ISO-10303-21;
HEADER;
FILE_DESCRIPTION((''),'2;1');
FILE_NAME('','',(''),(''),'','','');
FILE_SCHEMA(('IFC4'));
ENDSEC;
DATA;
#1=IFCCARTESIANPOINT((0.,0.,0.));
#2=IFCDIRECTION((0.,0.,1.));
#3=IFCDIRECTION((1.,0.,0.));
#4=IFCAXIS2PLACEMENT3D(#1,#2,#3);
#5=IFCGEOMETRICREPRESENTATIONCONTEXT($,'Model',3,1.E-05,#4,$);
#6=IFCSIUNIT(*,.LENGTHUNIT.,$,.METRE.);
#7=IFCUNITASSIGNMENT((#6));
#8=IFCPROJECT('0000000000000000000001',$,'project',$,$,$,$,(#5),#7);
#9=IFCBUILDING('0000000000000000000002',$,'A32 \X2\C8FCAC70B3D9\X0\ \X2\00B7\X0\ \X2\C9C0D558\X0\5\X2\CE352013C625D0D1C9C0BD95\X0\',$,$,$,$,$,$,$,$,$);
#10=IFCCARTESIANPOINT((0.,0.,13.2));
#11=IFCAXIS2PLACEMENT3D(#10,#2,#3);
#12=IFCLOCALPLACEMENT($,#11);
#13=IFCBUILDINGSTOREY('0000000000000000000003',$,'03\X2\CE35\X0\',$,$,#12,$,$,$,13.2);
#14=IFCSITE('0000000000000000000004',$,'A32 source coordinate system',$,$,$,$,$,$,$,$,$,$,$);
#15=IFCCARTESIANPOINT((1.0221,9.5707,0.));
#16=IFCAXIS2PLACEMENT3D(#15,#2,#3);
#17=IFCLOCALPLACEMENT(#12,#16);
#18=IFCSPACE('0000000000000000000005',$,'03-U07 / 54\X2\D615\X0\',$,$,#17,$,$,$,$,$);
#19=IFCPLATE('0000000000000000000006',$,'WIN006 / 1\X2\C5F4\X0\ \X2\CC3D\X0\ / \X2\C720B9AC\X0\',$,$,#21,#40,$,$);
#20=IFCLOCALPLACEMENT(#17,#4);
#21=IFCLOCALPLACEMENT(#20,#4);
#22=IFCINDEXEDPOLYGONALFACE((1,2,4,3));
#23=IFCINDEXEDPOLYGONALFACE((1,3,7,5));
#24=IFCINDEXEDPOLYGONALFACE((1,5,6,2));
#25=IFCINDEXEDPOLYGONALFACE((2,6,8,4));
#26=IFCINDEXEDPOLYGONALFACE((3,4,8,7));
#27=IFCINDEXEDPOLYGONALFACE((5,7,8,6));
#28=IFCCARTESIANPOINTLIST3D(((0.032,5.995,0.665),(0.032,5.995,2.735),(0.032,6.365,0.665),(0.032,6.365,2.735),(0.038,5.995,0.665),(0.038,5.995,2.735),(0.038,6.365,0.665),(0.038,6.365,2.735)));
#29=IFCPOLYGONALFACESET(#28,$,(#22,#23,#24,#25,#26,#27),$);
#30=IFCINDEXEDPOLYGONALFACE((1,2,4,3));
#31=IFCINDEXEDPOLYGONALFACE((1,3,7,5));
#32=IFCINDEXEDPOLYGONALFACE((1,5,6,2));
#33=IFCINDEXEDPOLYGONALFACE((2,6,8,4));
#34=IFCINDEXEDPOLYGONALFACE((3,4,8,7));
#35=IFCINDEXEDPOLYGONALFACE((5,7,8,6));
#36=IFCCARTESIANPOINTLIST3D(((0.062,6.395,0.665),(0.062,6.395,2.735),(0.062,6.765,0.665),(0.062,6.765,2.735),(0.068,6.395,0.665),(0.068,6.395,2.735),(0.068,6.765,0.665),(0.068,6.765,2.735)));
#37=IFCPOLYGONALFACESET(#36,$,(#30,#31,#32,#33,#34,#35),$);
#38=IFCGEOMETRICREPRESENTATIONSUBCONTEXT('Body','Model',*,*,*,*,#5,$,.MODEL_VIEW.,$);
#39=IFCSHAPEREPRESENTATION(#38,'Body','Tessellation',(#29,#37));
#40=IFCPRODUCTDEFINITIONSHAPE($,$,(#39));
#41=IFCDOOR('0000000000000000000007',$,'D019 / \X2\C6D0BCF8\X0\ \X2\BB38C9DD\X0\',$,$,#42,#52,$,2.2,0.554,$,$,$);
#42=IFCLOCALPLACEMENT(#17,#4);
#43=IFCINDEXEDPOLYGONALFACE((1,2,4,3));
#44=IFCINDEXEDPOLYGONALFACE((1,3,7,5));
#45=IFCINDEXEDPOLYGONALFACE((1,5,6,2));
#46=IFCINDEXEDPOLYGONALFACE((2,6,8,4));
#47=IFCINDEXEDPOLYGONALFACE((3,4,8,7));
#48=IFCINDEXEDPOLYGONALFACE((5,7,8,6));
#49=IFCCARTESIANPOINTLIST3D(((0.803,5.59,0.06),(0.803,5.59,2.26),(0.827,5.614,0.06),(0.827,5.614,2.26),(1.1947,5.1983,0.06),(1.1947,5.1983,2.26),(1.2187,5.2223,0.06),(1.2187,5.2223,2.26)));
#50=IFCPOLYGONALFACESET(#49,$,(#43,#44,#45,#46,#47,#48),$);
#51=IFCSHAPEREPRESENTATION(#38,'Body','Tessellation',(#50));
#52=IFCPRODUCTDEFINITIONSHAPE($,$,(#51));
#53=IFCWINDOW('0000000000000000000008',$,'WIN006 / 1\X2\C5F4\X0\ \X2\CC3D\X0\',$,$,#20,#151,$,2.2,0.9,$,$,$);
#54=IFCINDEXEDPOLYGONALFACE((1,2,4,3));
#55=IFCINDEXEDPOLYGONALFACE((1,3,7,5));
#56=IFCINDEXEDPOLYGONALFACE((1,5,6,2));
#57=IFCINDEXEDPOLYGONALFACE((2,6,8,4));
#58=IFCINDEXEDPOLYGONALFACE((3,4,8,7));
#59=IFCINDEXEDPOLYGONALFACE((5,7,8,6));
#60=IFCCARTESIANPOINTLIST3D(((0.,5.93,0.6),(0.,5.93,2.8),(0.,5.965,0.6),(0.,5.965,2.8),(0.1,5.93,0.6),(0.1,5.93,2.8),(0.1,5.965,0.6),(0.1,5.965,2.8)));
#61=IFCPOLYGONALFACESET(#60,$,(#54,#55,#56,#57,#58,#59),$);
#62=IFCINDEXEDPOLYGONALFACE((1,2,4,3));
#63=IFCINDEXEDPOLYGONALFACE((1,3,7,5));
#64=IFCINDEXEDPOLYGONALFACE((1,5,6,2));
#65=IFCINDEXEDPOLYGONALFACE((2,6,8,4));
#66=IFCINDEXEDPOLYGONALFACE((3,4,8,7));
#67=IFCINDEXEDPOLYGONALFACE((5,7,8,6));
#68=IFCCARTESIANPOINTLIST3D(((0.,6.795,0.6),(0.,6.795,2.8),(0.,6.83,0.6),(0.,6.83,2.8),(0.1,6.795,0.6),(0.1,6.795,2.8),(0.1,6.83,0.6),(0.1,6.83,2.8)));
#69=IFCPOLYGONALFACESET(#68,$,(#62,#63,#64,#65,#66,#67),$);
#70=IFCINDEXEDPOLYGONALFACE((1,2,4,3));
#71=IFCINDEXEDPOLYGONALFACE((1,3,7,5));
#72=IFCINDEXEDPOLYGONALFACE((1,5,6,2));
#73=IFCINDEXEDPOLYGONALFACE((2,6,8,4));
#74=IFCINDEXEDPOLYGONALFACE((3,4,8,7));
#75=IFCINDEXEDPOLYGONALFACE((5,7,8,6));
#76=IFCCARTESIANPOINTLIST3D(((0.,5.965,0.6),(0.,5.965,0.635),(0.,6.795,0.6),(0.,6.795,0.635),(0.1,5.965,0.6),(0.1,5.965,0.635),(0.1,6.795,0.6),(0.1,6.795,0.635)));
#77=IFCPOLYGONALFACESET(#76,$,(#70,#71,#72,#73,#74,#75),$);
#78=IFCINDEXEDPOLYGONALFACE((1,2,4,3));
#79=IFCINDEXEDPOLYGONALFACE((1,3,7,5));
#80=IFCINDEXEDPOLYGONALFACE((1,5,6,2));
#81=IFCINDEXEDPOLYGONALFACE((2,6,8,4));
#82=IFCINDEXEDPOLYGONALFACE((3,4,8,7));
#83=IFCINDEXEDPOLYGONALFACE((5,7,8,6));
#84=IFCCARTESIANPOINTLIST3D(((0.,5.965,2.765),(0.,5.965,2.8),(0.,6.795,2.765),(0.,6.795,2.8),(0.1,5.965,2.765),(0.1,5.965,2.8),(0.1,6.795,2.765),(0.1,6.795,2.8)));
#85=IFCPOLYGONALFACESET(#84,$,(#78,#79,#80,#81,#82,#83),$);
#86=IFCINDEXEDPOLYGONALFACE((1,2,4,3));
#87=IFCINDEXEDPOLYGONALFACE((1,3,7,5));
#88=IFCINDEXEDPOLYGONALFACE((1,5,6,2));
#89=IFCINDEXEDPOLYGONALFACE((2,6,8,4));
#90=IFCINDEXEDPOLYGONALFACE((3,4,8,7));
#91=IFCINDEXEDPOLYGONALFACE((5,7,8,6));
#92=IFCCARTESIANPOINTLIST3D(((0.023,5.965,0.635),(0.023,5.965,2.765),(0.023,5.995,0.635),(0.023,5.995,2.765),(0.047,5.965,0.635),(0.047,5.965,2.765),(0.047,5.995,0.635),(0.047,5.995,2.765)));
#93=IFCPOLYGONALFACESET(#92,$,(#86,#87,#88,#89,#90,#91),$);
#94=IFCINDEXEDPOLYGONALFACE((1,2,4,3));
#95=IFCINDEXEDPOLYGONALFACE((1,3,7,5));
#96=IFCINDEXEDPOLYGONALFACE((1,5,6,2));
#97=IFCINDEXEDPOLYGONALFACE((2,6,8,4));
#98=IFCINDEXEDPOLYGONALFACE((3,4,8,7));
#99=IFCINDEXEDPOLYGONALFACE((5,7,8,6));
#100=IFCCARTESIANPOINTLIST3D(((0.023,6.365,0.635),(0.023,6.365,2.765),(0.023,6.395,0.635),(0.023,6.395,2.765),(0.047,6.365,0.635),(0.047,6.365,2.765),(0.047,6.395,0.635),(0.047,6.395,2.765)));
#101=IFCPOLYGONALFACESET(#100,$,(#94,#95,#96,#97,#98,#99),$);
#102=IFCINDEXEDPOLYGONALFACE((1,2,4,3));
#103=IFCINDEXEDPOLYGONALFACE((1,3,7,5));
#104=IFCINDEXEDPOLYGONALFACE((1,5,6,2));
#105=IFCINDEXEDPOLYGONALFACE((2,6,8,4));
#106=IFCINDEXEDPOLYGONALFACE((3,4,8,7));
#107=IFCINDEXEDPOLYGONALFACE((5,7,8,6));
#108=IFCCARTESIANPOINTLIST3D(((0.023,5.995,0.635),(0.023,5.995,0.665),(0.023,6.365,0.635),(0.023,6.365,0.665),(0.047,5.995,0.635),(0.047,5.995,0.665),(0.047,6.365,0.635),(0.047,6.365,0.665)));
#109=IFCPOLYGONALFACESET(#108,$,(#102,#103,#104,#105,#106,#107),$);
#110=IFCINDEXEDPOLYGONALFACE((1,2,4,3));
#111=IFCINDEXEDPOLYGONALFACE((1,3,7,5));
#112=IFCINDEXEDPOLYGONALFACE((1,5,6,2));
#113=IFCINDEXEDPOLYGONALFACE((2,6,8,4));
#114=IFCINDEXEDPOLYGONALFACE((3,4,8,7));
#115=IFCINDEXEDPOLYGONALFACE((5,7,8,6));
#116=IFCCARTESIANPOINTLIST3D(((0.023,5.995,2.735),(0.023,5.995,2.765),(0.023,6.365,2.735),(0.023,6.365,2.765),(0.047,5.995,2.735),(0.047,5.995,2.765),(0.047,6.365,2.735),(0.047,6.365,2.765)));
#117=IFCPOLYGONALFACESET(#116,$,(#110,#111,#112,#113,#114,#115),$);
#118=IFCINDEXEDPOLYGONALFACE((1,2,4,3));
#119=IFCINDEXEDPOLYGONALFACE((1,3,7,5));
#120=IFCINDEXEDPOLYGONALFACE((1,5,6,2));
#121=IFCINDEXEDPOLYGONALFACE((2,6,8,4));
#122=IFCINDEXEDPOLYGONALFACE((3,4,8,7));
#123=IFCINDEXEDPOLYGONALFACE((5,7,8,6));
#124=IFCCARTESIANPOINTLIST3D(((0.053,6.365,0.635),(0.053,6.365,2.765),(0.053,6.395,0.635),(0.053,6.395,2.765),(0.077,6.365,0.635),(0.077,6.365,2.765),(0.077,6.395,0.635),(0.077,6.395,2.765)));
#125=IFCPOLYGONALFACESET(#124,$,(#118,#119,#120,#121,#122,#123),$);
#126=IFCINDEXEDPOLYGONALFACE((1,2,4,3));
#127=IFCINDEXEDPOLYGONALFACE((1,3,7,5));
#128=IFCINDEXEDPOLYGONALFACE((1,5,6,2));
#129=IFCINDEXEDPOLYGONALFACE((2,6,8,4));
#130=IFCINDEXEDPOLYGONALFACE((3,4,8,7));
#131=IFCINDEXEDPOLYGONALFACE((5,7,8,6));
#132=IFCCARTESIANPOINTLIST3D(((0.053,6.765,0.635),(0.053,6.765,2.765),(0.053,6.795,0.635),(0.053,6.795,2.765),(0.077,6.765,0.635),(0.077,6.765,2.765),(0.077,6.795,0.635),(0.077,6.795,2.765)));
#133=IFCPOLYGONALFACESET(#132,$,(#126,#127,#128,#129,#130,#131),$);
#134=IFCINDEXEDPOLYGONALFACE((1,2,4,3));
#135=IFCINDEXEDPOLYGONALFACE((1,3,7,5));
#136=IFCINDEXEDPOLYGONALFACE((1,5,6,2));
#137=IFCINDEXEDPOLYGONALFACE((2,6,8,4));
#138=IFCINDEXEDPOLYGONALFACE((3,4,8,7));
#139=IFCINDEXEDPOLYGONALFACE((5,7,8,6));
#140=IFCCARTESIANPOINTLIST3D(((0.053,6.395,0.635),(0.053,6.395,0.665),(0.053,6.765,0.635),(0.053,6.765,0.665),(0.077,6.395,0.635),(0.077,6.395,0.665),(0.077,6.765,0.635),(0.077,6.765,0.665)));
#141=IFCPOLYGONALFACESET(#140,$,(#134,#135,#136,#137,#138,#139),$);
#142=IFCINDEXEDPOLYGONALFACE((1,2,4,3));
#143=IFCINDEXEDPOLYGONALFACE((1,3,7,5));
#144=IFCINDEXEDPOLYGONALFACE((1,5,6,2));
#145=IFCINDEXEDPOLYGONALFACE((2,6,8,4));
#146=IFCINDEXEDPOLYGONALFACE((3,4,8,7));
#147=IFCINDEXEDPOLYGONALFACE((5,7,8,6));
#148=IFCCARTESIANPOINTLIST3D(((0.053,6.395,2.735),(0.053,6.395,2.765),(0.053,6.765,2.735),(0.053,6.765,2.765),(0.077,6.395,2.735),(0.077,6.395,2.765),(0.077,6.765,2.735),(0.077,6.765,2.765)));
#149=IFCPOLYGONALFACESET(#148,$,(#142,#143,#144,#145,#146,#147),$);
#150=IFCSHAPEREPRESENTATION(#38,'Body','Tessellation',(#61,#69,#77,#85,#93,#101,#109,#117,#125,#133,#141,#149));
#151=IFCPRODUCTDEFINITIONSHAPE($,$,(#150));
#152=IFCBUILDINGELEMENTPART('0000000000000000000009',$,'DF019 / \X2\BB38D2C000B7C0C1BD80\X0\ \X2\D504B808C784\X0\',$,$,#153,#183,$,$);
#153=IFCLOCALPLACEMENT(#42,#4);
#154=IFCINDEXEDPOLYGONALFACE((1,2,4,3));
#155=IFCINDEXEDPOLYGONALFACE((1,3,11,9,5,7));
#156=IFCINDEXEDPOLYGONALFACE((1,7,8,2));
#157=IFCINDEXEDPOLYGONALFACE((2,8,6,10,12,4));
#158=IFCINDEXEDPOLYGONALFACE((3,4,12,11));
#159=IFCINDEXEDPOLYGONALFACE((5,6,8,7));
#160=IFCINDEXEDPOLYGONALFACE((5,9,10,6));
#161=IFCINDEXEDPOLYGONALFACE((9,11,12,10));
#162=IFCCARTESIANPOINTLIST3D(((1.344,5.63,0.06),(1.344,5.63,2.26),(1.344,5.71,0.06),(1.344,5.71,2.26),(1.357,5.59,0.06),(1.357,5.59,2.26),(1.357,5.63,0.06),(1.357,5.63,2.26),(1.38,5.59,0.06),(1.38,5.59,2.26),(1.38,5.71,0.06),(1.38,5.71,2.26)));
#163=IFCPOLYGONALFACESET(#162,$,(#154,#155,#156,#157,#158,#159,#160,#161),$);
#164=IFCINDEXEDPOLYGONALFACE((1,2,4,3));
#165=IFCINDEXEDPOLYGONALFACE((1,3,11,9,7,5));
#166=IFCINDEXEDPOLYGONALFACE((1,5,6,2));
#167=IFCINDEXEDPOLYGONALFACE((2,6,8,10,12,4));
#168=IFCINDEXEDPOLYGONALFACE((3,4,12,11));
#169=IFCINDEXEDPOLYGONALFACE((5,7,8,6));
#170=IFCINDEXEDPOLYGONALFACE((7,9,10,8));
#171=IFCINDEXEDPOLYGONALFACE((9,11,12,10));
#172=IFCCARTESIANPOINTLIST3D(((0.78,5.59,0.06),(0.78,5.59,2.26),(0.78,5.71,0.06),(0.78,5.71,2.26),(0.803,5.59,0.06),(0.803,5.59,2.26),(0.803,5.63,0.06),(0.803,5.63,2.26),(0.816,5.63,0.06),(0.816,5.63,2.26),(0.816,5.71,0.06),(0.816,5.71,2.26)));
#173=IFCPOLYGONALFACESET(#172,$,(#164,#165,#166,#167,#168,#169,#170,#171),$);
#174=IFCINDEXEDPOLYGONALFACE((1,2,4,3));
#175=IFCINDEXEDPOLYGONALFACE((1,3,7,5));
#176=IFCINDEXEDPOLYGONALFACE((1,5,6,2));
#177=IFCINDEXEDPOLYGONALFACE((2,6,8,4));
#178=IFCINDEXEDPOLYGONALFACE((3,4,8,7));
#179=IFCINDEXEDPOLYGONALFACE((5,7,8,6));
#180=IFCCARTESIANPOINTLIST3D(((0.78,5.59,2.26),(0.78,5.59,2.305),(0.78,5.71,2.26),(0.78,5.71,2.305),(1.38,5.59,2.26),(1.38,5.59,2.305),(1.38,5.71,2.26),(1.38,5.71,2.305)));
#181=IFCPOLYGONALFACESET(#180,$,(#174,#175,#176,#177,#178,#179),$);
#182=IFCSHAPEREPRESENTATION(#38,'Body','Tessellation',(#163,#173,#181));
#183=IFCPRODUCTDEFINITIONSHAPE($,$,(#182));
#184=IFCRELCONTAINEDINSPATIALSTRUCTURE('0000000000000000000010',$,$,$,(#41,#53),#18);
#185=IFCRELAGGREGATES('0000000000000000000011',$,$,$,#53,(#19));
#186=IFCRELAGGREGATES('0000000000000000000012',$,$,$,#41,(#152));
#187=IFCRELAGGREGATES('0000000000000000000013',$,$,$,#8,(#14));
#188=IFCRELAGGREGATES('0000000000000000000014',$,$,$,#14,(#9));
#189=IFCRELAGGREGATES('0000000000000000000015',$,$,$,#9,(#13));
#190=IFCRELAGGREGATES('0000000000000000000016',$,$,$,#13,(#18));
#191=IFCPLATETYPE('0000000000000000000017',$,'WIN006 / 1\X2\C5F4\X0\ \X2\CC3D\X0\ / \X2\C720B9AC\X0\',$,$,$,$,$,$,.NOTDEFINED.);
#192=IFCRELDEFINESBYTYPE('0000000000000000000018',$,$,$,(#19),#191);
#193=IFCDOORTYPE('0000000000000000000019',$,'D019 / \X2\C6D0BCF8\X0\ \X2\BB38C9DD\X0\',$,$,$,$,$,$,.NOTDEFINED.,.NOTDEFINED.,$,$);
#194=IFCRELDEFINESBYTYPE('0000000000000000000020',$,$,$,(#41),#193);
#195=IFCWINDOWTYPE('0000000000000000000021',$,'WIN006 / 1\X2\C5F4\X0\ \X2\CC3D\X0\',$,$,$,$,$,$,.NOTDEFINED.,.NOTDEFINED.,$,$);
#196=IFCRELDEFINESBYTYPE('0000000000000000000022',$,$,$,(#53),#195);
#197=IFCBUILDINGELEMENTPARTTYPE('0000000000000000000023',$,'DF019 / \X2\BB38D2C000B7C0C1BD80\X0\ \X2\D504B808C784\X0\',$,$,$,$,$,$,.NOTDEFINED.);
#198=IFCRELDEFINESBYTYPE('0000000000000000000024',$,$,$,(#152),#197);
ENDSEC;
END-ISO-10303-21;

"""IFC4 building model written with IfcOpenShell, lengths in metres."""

from ifc_helpers import new_model, si_unit, frame, origin, origin_with_axes, place, context, subcontext, project, spatial, polyline, outline, extrude, source, transform, mapped, type_object, type_shapes, element, aggregate, save


model = new_model("IFC4")

# Units and contexts
model_context = context("Model", 3, precision=1e-05, world=origin_with_axes())
body_context = subcontext(model_context, "Body", "Model", "MODEL_VIEW")
ifc_project = project(units=[si_unit("LENGTHUNIT", "METRE")], contexts=[model_context])

# Plate
storey_placement = place(None, frame((0.0, 0.0, 13.2), z_axis=(0.0, 0.0, 1.0), x_axis=(1.0, 0.0, 0.0)))
space_placement = place(storey_placement, frame((1.0221, 9.5707, 0.0), z_axis=(0.0, 0.0, 1.0), x_axis=(1.0, 0.0, 0.0)))
plate_type_1 = type_object("IfcPlateType", Name="WIN006 / 1열 창 / 유리", PredefinedType="NOTDEFINED")
shared_shape_1 = source(origin(), body_context, "Body", "SweptSolid", [
    extrude(outline(polyline([(0.032, 5.995), (0.032, 6.365), (0.038, 6.365), (0.038, 5.995), (0.032, 5.995)])), frame((0.0, 0.0, 0.665)), (0.0, 0.0, 1.0), 2.07),
    extrude(outline(polyline([(0.062, 6.395), (0.062, 6.765), (0.068, 6.765), (0.068, 6.395), (0.062, 6.395)])), frame((0.0, 0.0, 0.665)), (0.0, 0.0, 1.0), 2.07),
])
type_shapes(plate_type_1, [shared_shape_1])
window_1_placement = place(space_placement, origin_with_axes())
plate_1_placement = place(window_1_placement, origin_with_axes())
plate_1 = element("IfcPlate", 1, at=plate_1_placement, type_object=plate_type_1, Name="WIN006 / 1열 창 / 유리", context=body_context, shape_type="MappedRepresentation", body=[
    mapped(shared_shape_1, transform((0.0, 0.0, 0.0), scale=1.0)),
])

# Site, building, storey, space
site = spatial("IfcSite", under=ifc_project, Name="A32 source coordinate system")
building = spatial("IfcBuilding", under=site, Name="A32 주거동 · 지하5층–옥탑지붕")
storey = spatial("IfcBuildingStorey", under=building, at=storey_placement, Name="03층", Elevation=13.2)
space = spatial("IfcSpace", under=storey, at=space_placement, Name="03-U07 / 54형")

# Door
door_type_1 = type_object("IfcDoorType", Name="D019 / 원본 문짝", OperationType="NOTDEFINED", PredefinedType="NOTDEFINED")
shared_shape_2 = source(origin(), body_context, "Body", "SweptSolid", [
    extrude(outline(polyline([(1.2187, 5.2223), (1.1947, 5.1983), (0.803, 5.59), (0.827, 5.614), (1.2187, 5.2223)])), frame((0.0, 0.0, 0.06)), (0.0, 0.0, 1.0), 2.2),
])
type_shapes(door_type_1, [shared_shape_2])
door_1_placement = place(space_placement, origin_with_axes())
door_1 = element("IfcDoor", 2, at=door_1_placement, inside=space, type_object=door_type_1, Name="D019 / 원본 문짝", OverallHeight=2.2, OverallWidth=0.554, context=body_context, shape_type="MappedRepresentation", body=[
    mapped(shared_shape_2, transform((0.0, 0.0, 0.0), scale=1.0)),
])

# Window
window_type_1 = type_object("IfcWindowType", Name="WIN006 / 1열 창", PartitioningType="NOTDEFINED", PredefinedType="NOTDEFINED")
shared_shape_3 = source(origin(), body_context, "Body", "SweptSolid", [
    extrude(outline(polyline([(0.0, 5.93), (0.0, 5.965), (0.1, 5.965), (0.1, 5.93), (0.0, 5.93)])), frame((0.0, 0.0, 0.6)), (0.0, 0.0, 1.0), 2.2),
    extrude(outline(polyline([(0.0, 6.795), (0.0, 6.83), (0.1, 6.83), (0.1, 6.795), (0.0, 6.795)])), frame((0.0, 0.0, 0.6)), (0.0, 0.0, 1.0), 2.2),
    extrude(outline(polyline([(0.0, 5.965), (0.0, 6.795), (0.1, 6.795), (0.1, 5.965), (0.0, 5.965)])), frame((0.0, 0.0, 0.6)), (0.0, 0.0, 1.0), 0.035),
    extrude(outline(polyline([(0.0, 5.965), (0.0, 6.795), (0.1, 6.795), (0.1, 5.965), (0.0, 5.965)])), frame((0.0, 0.0, 2.765)), (0.0, 0.0, 1.0), 0.035),
    extrude(outline(polyline([(0.023, 5.965), (0.023, 5.995), (0.047, 5.995), (0.047, 5.965), (0.023, 5.965)])), frame((0.0, 0.0, 0.635)), (0.0, 0.0, 1.0), 2.13),
    extrude(outline(polyline([(0.023, 6.365), (0.023, 6.395), (0.047, 6.395), (0.047, 6.365), (0.023, 6.365)])), frame((0.0, 0.0, 0.635)), (0.0, 0.0, 1.0), 2.13),
    extrude(outline(polyline([(0.023, 5.995), (0.023, 6.365), (0.047, 6.365), (0.047, 5.995), (0.023, 5.995)])), frame((0.0, 0.0, 0.635)), (0.0, 0.0, 1.0), 0.03),
    extrude(outline(polyline([(0.023, 5.995), (0.023, 6.365), (0.047, 6.365), (0.047, 5.995), (0.023, 5.995)])), frame((0.0, 0.0, 2.735)), (0.0, 0.0, 1.0), 0.03),
    extrude(outline(polyline([(0.053, 6.365), (0.053, 6.395), (0.077, 6.395), (0.077, 6.365), (0.053, 6.365)])), frame((0.0, 0.0, 0.635)), (0.0, 0.0, 1.0), 2.13),
    extrude(outline(polyline([(0.053, 6.765), (0.053, 6.795), (0.077, 6.795), (0.077, 6.765), (0.053, 6.765)])), frame((0.0, 0.0, 0.635)), (0.0, 0.0, 1.0), 2.13),
    extrude(outline(polyline([(0.053, 6.395), (0.053, 6.765), (0.077, 6.765), (0.077, 6.395), (0.053, 6.395)])), frame((0.0, 0.0, 0.635)), (0.0, 0.0, 1.0), 0.03),
    extrude(outline(polyline([(0.053, 6.395), (0.053, 6.765), (0.077, 6.765), (0.077, 6.395), (0.053, 6.395)])), frame((0.0, 0.0, 2.735)), (0.0, 0.0, 1.0), 0.03),
])
type_shapes(window_type_1, [shared_shape_3])
window_1 = element("IfcWindow", 3, at=window_1_placement, inside=space, type_object=window_type_1, Name="WIN006 / 1열 창", OverallHeight=2.2, OverallWidth=0.9, context=body_context, shape_type="MappedRepresentation", body=[
    mapped(shared_shape_3, transform((0.0, 0.0, 0.0), scale=1.0)),
])
aggregate(window_1, [plate_1])

# Building element part
building_element_part_type_1 = type_object("IfcBuildingElementPartType", Name="DF019 / 문틀·상부 프레임", PredefinedType="NOTDEFINED")
shared_shape_4 = source(origin(), body_context, "Body", "SweptSolid", [
    extrude(outline(polyline([(1.38, 5.59), (1.357, 5.59), (1.357, 5.63), (1.344, 5.63), (1.344, 5.71), (1.38, 5.71), (1.38, 5.59)])), frame((0.0, 0.0, 0.06)), (0.0, 0.0, 1.0), 2.2),
    extrude(outline(polyline([(0.816, 5.71), (0.816, 5.63), (0.803, 5.63), (0.803, 5.59), (0.78, 5.59), (0.78, 5.71), (0.816, 5.71)])), frame((0.0, 0.0, 0.06)), (0.0, 0.0, 1.0), 2.2),
    extrude(outline(polyline([(0.78, 5.59), (0.78, 5.71), (1.38, 5.71), (1.38, 5.59), (0.78, 5.59)])), frame((0.0, 0.0, 2.26)), (0.0, 0.0, 1.0), 0.045),
])
type_shapes(building_element_part_type_1, [shared_shape_4])
building_element_part_1_placement = place(door_1_placement, origin_with_axes())
building_element_part_1 = element("IfcBuildingElementPart", 4, at=building_element_part_1_placement, type_object=building_element_part_type_1, Name="DF019 / 문틀·상부 프레임", context=body_context, shape_type="MappedRepresentation", body=[
    mapped(shared_shape_4, transform((0.0, 0.0, 0.0), scale=1.0)),
])
aggregate(door_1, [building_element_part_1])

save(model, "model.ifc")
